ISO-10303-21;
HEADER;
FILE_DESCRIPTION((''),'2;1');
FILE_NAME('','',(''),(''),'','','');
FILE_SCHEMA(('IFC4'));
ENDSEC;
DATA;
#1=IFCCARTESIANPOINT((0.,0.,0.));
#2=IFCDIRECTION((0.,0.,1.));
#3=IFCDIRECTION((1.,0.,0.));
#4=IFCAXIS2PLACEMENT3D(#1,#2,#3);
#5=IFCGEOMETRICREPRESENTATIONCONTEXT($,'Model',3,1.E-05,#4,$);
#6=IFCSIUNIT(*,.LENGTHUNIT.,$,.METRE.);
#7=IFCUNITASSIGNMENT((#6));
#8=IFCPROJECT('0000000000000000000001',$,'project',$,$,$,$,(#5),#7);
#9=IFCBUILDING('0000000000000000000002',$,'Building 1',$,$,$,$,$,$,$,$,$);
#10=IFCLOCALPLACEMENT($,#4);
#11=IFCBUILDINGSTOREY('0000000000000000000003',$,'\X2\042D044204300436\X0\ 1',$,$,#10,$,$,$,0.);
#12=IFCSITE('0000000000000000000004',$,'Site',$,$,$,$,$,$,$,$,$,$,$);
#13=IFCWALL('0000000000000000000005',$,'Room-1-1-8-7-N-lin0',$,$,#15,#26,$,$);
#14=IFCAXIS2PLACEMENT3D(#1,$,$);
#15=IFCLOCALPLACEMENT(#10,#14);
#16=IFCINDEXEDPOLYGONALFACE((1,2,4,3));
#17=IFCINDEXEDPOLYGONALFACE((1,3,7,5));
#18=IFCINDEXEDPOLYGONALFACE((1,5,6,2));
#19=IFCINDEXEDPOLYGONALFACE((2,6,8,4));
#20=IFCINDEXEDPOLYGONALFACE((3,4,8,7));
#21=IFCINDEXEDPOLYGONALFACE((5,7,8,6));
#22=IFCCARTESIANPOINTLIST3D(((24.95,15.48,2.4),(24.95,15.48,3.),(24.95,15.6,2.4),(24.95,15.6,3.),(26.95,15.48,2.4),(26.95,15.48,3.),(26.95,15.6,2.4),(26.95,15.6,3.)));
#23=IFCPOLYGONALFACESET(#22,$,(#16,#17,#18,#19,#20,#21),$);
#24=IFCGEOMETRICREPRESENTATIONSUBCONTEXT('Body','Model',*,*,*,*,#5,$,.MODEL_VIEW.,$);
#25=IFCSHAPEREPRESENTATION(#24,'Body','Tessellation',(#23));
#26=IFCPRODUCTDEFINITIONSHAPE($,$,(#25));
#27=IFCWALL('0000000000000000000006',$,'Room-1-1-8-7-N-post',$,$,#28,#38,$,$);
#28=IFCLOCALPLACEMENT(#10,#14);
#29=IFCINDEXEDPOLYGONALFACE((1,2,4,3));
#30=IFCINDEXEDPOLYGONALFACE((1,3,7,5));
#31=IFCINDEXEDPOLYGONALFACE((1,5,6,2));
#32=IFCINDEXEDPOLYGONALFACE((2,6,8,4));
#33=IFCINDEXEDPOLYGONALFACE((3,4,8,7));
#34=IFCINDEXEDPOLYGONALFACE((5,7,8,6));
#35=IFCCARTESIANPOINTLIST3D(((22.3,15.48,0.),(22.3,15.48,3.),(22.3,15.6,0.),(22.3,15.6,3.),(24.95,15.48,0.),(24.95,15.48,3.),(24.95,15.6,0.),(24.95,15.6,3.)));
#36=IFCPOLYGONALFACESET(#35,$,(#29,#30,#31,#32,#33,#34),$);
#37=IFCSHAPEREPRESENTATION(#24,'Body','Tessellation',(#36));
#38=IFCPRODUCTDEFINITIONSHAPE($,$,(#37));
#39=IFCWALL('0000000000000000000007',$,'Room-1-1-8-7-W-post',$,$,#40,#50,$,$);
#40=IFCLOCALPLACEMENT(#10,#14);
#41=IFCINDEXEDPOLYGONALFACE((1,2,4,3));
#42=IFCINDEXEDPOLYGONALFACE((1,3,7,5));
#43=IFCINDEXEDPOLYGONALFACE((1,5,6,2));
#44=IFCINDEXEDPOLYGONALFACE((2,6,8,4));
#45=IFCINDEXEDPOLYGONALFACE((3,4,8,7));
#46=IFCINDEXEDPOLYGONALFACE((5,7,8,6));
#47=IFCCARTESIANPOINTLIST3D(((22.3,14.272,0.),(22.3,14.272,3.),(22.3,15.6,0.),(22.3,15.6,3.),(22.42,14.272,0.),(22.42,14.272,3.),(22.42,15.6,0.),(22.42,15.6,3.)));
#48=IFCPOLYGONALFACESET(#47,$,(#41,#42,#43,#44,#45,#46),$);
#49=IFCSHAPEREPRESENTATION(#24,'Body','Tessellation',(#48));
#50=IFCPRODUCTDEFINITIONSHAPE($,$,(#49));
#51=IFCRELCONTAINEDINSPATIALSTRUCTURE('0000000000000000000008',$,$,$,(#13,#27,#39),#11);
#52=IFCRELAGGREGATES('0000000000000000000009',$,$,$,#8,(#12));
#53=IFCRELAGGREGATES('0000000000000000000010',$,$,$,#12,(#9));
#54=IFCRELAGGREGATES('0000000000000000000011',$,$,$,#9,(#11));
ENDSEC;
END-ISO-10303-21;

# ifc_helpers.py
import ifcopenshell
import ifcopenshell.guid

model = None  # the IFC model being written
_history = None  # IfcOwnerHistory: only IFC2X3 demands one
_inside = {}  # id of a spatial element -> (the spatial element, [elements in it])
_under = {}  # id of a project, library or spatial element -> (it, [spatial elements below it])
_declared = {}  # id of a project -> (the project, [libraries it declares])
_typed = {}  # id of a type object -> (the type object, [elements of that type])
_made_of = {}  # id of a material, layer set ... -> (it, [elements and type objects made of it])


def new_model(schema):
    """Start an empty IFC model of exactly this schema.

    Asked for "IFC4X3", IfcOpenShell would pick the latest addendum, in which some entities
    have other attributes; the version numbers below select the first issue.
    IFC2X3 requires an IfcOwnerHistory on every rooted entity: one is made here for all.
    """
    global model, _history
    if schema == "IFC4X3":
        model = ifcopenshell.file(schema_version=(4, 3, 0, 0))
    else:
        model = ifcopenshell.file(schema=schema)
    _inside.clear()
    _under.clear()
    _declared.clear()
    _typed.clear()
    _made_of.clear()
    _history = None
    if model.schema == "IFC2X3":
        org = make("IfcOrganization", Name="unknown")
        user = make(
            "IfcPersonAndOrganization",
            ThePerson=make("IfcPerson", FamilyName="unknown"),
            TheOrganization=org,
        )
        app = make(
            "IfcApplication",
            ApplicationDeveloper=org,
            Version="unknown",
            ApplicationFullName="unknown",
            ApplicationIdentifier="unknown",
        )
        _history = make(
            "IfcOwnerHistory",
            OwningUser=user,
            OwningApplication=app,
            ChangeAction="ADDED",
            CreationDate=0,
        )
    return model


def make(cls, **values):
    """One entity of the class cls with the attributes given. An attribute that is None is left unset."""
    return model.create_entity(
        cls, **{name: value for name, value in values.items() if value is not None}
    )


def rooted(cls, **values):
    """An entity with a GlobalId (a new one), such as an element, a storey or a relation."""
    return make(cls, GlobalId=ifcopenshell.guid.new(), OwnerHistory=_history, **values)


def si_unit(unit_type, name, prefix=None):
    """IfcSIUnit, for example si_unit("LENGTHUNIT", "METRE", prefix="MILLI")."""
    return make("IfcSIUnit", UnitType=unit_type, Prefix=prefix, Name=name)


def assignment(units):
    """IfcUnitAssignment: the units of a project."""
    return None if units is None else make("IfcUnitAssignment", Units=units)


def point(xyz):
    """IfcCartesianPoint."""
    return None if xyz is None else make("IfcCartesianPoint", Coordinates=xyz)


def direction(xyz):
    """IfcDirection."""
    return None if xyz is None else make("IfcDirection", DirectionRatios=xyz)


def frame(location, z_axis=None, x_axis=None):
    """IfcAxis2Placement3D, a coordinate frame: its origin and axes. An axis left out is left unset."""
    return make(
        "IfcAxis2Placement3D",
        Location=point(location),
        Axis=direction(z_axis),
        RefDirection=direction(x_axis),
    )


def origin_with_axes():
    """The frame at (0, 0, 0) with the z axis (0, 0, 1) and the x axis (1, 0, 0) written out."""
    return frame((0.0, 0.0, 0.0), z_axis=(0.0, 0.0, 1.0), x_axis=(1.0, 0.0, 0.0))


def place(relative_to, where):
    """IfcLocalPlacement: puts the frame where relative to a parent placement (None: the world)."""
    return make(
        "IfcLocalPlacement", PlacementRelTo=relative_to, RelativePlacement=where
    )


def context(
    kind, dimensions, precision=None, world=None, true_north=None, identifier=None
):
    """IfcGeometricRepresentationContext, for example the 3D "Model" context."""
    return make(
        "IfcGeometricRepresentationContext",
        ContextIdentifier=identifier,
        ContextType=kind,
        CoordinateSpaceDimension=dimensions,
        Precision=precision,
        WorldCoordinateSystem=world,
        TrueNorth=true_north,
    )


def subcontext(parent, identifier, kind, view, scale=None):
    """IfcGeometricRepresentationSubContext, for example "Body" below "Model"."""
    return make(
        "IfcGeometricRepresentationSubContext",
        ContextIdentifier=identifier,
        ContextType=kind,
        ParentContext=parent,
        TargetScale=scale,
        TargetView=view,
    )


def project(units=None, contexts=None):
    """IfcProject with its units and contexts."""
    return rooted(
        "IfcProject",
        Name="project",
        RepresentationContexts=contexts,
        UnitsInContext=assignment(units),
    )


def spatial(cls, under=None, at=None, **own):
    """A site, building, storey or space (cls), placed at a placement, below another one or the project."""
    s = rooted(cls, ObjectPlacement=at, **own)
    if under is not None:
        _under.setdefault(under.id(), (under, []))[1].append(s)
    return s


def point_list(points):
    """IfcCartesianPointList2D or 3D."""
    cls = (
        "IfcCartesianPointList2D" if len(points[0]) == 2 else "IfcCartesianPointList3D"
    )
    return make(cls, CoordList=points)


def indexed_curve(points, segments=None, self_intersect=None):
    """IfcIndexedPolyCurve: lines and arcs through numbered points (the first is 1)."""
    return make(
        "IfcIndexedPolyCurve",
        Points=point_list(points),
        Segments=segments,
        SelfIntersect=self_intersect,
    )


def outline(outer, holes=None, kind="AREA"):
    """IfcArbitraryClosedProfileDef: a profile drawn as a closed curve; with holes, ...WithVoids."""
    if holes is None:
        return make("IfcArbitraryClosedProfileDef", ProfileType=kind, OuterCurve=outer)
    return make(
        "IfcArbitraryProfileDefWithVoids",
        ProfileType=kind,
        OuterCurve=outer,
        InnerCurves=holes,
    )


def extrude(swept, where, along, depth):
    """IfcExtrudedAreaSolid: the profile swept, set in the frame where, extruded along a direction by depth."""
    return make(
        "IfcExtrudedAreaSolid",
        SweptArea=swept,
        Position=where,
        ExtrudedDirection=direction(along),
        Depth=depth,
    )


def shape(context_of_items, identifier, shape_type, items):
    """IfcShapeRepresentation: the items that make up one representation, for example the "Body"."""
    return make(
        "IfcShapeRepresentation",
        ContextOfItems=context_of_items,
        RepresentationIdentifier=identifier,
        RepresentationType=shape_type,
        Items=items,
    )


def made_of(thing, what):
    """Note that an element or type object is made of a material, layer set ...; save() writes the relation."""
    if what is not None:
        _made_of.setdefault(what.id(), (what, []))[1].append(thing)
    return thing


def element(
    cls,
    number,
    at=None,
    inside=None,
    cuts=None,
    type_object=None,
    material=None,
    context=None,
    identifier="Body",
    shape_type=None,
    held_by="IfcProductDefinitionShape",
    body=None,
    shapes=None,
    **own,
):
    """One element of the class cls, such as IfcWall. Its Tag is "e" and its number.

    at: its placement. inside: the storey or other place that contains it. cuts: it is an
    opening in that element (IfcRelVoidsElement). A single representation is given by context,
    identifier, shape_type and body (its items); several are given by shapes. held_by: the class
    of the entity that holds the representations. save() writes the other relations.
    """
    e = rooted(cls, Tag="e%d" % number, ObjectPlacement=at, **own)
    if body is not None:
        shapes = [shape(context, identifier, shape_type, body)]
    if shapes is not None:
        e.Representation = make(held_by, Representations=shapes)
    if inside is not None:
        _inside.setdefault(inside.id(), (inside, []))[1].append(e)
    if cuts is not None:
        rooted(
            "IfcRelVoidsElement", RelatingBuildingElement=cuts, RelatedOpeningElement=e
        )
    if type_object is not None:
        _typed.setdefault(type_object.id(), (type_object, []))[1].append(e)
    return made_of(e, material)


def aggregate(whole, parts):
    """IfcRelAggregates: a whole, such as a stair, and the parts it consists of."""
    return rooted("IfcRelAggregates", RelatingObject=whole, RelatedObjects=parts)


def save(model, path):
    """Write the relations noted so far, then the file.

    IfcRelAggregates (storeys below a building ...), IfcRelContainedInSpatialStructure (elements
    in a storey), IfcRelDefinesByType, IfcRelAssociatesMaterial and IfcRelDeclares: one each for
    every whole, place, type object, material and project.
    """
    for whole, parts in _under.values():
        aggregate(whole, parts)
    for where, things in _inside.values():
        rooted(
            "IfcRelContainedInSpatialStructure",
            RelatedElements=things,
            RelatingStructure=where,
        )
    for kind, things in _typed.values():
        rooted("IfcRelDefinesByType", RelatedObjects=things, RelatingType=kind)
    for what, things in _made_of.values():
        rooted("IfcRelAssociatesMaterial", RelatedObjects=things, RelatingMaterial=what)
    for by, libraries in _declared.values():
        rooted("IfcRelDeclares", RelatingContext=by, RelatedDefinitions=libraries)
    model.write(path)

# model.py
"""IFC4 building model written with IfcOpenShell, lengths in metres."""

from ifc_helpers import new_model, si_unit, frame, origin_with_axes, place, context, subcontext, project, spatial, indexed_curve, outline, extrude, element, save


model = new_model("IFC4")

# Units and contexts
model_context = context("Model", 3, precision=1e-05, world=origin_with_axes())
body_context = subcontext(model_context, "Body", "Model", "MODEL_VIEW")
ifc_project = project(units=[si_unit("LENGTHUNIT", "METRE")], contexts=[model_context])

# Site, building, storey
site = spatial("IfcSite", under=ifc_project, Name="Site")
building = spatial("IfcBuilding", under=site, Name="Building 1")
storey_placement = place(None, origin_with_axes())
storey = spatial("IfcBuildingStorey", under=building, at=storey_placement, Name="Этаж 1", Elevation=0.0)

# Walls
wall_1_placement = place(storey_placement, frame((26.95, 15.6, 2.4), z_axis=(0.0, 0.0, 1.0), x_axis=(-1.0, 0.0, 0.0)))
element("IfcWall", 1, at=wall_1_placement, inside=storey, Name="Room-1-1-8-7-N-lin0", context=body_context, shape_type="SweptSolid", body=[
    extrude(outline(indexed_curve([(0.0, 0.0), (0.0, 0.12), (2.0, 0.12), (2.0, 0.0), (0.0, 0.0)], self_intersect=False)), origin_with_axes(), (0.0, 0.0, 1.0), 0.6),
])
wall_2_placement = place(storey_placement, frame((24.95, 15.6, 0.0), z_axis=(0.0, 0.0, 1.0), x_axis=(-1.0, 0.0, 0.0)))
element("IfcWall", 2, at=wall_2_placement, inside=storey, Name="Room-1-1-8-7-N-post", context=body_context, shape_type="SweptSolid", body=[
    extrude(outline(indexed_curve([(0.0, 0.0), (0.0, 0.12), (2.65, 0.12), (2.65, 0.0), (0.0, 0.0)], self_intersect=False)), origin_with_axes(), (0.0, 0.0, 1.0), 3.0),
])
wall_3_placement = place(storey_placement, frame((22.3, 15.6, 0.0), z_axis=(0.0, 0.0, 1.0), x_axis=(0.0, -1.0, 0.0)))
element("IfcWall", 3, at=wall_3_placement, inside=storey, Name="Room-1-1-8-7-W-post", context=body_context, shape_type="SweptSolid", body=[
    extrude(outline(indexed_curve([(0.0, 0.0), (0.0, 0.12), (1.328, 0.12), (1.328, 0.0), (0.0, 0.0)], self_intersect=False)), origin_with_axes(), (0.0, 0.0, 1.0), 3.0),
])

save(model, "model.ifc")
